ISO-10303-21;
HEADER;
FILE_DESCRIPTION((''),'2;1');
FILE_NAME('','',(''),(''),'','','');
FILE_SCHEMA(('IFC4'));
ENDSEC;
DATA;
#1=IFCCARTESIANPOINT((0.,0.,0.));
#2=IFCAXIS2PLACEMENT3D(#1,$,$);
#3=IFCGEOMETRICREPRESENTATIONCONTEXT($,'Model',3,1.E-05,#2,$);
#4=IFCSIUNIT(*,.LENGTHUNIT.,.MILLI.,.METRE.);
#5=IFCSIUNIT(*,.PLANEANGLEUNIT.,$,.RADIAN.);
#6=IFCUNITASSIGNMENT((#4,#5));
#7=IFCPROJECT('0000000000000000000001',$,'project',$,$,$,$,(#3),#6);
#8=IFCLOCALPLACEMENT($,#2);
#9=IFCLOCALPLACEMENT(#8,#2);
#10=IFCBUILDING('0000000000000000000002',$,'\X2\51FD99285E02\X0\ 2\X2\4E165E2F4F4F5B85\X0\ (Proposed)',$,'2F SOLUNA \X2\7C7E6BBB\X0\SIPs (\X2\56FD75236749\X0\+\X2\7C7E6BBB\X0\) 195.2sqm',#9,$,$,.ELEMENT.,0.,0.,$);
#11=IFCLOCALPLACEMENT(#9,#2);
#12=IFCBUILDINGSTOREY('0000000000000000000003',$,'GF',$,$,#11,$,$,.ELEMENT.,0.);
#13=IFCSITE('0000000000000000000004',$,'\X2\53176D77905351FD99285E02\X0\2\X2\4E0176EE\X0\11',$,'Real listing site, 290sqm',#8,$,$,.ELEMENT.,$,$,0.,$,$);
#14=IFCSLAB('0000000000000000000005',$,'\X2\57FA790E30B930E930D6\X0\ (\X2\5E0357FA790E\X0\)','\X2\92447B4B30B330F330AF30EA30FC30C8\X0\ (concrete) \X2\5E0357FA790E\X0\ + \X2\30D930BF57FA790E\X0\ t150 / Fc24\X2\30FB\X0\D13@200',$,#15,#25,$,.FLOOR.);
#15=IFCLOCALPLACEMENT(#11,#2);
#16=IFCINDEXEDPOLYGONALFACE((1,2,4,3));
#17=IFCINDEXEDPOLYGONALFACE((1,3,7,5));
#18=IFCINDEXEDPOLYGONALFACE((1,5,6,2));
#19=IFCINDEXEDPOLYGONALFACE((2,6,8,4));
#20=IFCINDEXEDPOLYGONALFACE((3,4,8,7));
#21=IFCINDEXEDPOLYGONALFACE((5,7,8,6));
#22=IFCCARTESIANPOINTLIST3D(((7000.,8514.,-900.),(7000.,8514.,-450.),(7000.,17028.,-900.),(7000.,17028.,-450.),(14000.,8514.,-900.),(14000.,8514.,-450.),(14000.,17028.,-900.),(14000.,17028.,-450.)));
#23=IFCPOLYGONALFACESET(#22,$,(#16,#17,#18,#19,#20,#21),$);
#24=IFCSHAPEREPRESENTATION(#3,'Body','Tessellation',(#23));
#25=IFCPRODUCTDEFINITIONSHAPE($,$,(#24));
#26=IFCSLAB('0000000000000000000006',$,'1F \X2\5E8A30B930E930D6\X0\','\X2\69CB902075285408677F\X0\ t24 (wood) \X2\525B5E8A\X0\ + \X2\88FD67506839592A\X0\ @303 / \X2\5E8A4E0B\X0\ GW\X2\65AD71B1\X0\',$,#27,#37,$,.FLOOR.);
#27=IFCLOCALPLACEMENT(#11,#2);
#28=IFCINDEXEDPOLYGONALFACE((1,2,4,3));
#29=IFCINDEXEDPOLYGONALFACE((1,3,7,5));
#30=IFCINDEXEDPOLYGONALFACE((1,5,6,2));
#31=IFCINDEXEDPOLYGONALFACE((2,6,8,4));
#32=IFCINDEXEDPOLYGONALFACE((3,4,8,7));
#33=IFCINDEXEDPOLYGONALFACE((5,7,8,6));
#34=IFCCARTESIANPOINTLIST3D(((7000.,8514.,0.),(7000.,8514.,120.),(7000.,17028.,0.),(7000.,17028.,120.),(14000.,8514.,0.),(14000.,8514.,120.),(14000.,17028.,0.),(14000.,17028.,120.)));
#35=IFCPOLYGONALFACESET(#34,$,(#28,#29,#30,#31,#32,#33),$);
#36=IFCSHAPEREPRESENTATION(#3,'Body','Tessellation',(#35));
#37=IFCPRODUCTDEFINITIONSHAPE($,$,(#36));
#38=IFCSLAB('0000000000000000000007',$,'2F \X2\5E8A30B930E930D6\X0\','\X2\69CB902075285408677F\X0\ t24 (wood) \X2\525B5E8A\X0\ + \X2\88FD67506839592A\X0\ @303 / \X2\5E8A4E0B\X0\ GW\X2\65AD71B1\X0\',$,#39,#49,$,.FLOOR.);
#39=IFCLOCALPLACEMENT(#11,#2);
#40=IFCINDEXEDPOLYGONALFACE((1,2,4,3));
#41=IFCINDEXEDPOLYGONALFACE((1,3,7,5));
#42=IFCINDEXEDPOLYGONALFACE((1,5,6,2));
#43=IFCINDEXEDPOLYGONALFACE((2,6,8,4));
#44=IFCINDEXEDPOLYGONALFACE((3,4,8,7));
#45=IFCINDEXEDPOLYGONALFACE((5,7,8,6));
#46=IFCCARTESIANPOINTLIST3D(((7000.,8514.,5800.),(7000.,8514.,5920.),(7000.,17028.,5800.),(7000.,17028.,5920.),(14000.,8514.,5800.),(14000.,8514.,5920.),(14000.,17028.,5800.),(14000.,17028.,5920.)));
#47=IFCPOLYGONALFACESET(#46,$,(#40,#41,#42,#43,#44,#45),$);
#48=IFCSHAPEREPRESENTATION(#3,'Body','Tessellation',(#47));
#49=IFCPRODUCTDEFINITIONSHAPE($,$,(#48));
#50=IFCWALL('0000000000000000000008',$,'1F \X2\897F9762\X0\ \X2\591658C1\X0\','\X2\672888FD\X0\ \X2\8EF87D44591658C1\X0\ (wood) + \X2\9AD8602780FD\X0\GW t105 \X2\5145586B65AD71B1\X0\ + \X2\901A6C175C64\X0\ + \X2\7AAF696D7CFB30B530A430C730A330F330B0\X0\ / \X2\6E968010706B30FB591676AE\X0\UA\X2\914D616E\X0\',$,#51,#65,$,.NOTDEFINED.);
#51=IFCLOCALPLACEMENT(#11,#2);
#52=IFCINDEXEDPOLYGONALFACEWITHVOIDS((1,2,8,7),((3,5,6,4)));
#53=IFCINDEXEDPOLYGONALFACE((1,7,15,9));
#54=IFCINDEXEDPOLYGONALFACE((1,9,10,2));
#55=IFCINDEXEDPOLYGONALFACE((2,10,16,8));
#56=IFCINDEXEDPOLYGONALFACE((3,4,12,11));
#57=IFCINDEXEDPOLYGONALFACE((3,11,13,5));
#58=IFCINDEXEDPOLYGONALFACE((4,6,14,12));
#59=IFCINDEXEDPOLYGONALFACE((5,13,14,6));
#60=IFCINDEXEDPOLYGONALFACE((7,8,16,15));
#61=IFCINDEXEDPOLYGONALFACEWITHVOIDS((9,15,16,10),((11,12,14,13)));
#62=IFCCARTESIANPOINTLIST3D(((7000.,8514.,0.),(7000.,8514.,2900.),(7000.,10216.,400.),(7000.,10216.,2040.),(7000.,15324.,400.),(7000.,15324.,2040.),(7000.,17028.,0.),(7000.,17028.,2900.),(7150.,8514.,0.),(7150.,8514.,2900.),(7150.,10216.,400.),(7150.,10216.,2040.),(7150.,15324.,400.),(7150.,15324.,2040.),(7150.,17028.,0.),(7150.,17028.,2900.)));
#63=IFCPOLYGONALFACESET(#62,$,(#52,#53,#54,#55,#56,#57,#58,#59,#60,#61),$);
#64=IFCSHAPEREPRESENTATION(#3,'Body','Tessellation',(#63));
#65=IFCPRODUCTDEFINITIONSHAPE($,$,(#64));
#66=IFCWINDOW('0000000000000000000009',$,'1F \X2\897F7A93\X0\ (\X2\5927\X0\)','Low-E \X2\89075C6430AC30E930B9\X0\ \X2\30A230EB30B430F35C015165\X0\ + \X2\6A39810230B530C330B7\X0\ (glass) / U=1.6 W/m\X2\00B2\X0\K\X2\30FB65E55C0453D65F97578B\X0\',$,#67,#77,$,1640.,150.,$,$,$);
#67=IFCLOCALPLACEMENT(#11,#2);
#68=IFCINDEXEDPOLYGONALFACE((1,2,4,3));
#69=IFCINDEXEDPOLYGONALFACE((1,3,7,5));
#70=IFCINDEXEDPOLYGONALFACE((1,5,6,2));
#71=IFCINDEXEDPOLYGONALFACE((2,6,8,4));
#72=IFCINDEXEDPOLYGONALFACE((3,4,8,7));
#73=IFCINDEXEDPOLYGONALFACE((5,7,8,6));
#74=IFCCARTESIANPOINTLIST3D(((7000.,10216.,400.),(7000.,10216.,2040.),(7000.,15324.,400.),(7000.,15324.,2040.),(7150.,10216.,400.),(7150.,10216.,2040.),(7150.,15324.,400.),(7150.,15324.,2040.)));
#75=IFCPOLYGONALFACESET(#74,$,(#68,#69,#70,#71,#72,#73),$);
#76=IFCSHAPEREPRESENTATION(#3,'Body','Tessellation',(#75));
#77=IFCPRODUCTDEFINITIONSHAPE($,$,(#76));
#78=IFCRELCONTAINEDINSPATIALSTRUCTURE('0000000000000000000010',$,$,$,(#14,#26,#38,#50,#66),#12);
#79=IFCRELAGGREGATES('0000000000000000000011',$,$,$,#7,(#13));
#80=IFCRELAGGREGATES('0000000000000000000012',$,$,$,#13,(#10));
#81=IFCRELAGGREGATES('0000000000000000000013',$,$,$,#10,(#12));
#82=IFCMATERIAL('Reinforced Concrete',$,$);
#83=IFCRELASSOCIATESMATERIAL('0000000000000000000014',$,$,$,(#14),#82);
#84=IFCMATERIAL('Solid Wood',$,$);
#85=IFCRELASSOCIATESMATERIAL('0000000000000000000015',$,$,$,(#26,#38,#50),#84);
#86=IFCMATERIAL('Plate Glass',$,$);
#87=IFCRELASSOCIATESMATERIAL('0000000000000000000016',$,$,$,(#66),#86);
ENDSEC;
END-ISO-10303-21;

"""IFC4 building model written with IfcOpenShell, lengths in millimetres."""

from ifc_helpers import new_model, si_unit, frame, frame_2d, origin, place, context, project, spatial, rectangle, extrude, material, element, fill, save


model = new_model("IFC4")

# Units and contexts
model_context = context("Model", 3, precision=1e-05, world=origin())
ifc_project = project(units=[si_unit("LENGTHUNIT", "METRE", prefix="MILLI"), si_unit("PLANEANGLEUNIT", "RADIAN")], contexts=[model_context])

# Site, building, storey
site_placement = place(None, origin())
site = spatial("IfcSite", under=ifc_project, at=site_placement, Name="北海道函館市2丁目11", ObjectType="Real listing site, 290sqm", CompositionType="ELEMENT", RefElevation=0.0)
building_placement = place(site_placement, origin())
building = spatial("IfcBuilding", under=site, at=building_placement, Name="函館市 2世帯住宅 (Proposed)", ObjectType="2F SOLUNA 籾殻SIPs (国産杉+籾殻) 195.2sqm", CompositionType="ELEMENT", ElevationOfRefHeight=0.0, ElevationOfTerrain=0.0)
storey_placement = place(building_placement, origin())
storey = spatial("IfcBuildingStorey", under=building, at=storey_placement, Name="GF", CompositionType="ELEMENT", Elevation=0.0)

# Slabs
ifc_material_1 = material(Name="Reinforced Concrete")
slab_1_placement = place(storey_placement, frame((3500.0, 4257.0, -450.0)))
element("IfcSlab", 1, at=slab_1_placement, inside=storey, material=ifc_material_1, Name="基礎スラブ (布基礎)", Description="鉄筋コンクリート (concrete) 布基礎 + ベタ基礎 t150 / Fc24・D13@200", PredefinedType="FLOOR", context=model_context, shape_type="SweptSolid", body=[
    extrude(rectangle(XDim=7000.0, YDim=8514.0, at=frame_2d((3500.0, 4257.0))), frame((3500.0, 4257.0, -450.0)), (0.0, 0.0, 1.0), 450.0),
])
ifc_material_2 = material(Name="Solid Wood")
slab_2_placement = place(storey_placement, frame((3500.0, 4257.0, 0.0)))
element("IfcSlab", 2, at=slab_2_placement, inside=storey, material=ifc_material_2, Name="1F 床スラブ", Description="構造用合板 t24 (wood) 剛床 + 製材根太 @303 / 床下 GW断熱", PredefinedType="FLOOR", context=model_context, shape_type="SweptSolid", body=[
    extrude(rectangle(XDim=7000.0, YDim=8514.0, at=frame_2d((3500.0, 4257.0))), frame((3500.0, 4257.0, 0.0)), (0.0, 0.0, 1.0), 120.0),
])
slab_3_placement = place(storey_placement, frame((3500.0, 4257.0, 2900.0)))
element("IfcSlab", 3, at=slab_3_placement, inside=storey, material=ifc_material_2, Name="2F 床スラブ", Description="構造用合板 t24 (wood) 剛床 + 製材根太 @303 / 床下 GW断熱", PredefinedType="FLOOR", context=model_context, shape_type="SweptSolid", body=[
    extrude(rectangle(XDim=7000.0, YDim=8514.0, at=frame_2d((3500.0, 4257.0))), frame((3500.0, 4257.0, 2900.0)), (0.0, 0.0, 1.0), 120.0),
])

# Shared definitions
ifc_material_3 = material(Name="Plate Glass")

# Wall, opening, window
wall_1_placement = place(storey_placement, frame((3500.0, 4257.0, 0.0)))
wall_1 = element("IfcWall", 4, at=wall_1_placement, inside=storey, material=ifc_material_2, Name="1F 西面 外壁", Description="木製 軸組外壁 (wood) + 高性能GW t105 充填断熱 + 通気層 + 窯業系サイディング / 準耐火・外皮UA配慮", PredefinedType="NOTDEFINED", context=model_context, shape_type="SweptSolid", body=[
    extrude(rectangle(XDim=150.0, YDim=8514.0, at=frame_2d((75.0, 4257.0))), frame((3500.0, 4257.0, 0.0)), (0.0, 0.0, 1.0), 2900.0),
])
opening_1_placement = place(storey_placement, frame((3500.0, 5108.0, 200.0)))
opening_1 = element("IfcOpeningElement", 5, at=opening_1_placement, cuts=wall_1, PredefinedType="NOTDEFINED", context=model_context, shape_type="SweptSolid", body=[
    extrude(rectangle(XDim=150.0, YDim=5108.0, at=frame_2d((75.0, 2554.0))), frame((3500.0, 5108.0, 200.0)), (0.0, 0.0, 1.0), 1640.0),
])
window_1_placement = place(storey_placement, frame((3500.0, 5108.0, 200.0)))
window_1 = element("IfcWindow", 6, at=window_1_placement, inside=storey, material=ifc_material_3, Name="1F 西窓 (大)", Description="Low-E 複層ガラス アルゴン封入 + 樹脂サッシ (glass) / U=1.6 W/m²K・日射取得型", OverallHeight=1640.0, OverallWidth=150.0, context=model_context, shape_type="SweptSolid", body=[
    extrude(rectangle(XDim=150.0, YDim=5108.0, at=frame_2d((75.0, 2554.0))), frame((3500.0, 5108.0, 200.0)), (0.0, 0.0, 1.0), 1640.0),
])
fill(opening_1, window_1)

save(model, "model.ifc")
